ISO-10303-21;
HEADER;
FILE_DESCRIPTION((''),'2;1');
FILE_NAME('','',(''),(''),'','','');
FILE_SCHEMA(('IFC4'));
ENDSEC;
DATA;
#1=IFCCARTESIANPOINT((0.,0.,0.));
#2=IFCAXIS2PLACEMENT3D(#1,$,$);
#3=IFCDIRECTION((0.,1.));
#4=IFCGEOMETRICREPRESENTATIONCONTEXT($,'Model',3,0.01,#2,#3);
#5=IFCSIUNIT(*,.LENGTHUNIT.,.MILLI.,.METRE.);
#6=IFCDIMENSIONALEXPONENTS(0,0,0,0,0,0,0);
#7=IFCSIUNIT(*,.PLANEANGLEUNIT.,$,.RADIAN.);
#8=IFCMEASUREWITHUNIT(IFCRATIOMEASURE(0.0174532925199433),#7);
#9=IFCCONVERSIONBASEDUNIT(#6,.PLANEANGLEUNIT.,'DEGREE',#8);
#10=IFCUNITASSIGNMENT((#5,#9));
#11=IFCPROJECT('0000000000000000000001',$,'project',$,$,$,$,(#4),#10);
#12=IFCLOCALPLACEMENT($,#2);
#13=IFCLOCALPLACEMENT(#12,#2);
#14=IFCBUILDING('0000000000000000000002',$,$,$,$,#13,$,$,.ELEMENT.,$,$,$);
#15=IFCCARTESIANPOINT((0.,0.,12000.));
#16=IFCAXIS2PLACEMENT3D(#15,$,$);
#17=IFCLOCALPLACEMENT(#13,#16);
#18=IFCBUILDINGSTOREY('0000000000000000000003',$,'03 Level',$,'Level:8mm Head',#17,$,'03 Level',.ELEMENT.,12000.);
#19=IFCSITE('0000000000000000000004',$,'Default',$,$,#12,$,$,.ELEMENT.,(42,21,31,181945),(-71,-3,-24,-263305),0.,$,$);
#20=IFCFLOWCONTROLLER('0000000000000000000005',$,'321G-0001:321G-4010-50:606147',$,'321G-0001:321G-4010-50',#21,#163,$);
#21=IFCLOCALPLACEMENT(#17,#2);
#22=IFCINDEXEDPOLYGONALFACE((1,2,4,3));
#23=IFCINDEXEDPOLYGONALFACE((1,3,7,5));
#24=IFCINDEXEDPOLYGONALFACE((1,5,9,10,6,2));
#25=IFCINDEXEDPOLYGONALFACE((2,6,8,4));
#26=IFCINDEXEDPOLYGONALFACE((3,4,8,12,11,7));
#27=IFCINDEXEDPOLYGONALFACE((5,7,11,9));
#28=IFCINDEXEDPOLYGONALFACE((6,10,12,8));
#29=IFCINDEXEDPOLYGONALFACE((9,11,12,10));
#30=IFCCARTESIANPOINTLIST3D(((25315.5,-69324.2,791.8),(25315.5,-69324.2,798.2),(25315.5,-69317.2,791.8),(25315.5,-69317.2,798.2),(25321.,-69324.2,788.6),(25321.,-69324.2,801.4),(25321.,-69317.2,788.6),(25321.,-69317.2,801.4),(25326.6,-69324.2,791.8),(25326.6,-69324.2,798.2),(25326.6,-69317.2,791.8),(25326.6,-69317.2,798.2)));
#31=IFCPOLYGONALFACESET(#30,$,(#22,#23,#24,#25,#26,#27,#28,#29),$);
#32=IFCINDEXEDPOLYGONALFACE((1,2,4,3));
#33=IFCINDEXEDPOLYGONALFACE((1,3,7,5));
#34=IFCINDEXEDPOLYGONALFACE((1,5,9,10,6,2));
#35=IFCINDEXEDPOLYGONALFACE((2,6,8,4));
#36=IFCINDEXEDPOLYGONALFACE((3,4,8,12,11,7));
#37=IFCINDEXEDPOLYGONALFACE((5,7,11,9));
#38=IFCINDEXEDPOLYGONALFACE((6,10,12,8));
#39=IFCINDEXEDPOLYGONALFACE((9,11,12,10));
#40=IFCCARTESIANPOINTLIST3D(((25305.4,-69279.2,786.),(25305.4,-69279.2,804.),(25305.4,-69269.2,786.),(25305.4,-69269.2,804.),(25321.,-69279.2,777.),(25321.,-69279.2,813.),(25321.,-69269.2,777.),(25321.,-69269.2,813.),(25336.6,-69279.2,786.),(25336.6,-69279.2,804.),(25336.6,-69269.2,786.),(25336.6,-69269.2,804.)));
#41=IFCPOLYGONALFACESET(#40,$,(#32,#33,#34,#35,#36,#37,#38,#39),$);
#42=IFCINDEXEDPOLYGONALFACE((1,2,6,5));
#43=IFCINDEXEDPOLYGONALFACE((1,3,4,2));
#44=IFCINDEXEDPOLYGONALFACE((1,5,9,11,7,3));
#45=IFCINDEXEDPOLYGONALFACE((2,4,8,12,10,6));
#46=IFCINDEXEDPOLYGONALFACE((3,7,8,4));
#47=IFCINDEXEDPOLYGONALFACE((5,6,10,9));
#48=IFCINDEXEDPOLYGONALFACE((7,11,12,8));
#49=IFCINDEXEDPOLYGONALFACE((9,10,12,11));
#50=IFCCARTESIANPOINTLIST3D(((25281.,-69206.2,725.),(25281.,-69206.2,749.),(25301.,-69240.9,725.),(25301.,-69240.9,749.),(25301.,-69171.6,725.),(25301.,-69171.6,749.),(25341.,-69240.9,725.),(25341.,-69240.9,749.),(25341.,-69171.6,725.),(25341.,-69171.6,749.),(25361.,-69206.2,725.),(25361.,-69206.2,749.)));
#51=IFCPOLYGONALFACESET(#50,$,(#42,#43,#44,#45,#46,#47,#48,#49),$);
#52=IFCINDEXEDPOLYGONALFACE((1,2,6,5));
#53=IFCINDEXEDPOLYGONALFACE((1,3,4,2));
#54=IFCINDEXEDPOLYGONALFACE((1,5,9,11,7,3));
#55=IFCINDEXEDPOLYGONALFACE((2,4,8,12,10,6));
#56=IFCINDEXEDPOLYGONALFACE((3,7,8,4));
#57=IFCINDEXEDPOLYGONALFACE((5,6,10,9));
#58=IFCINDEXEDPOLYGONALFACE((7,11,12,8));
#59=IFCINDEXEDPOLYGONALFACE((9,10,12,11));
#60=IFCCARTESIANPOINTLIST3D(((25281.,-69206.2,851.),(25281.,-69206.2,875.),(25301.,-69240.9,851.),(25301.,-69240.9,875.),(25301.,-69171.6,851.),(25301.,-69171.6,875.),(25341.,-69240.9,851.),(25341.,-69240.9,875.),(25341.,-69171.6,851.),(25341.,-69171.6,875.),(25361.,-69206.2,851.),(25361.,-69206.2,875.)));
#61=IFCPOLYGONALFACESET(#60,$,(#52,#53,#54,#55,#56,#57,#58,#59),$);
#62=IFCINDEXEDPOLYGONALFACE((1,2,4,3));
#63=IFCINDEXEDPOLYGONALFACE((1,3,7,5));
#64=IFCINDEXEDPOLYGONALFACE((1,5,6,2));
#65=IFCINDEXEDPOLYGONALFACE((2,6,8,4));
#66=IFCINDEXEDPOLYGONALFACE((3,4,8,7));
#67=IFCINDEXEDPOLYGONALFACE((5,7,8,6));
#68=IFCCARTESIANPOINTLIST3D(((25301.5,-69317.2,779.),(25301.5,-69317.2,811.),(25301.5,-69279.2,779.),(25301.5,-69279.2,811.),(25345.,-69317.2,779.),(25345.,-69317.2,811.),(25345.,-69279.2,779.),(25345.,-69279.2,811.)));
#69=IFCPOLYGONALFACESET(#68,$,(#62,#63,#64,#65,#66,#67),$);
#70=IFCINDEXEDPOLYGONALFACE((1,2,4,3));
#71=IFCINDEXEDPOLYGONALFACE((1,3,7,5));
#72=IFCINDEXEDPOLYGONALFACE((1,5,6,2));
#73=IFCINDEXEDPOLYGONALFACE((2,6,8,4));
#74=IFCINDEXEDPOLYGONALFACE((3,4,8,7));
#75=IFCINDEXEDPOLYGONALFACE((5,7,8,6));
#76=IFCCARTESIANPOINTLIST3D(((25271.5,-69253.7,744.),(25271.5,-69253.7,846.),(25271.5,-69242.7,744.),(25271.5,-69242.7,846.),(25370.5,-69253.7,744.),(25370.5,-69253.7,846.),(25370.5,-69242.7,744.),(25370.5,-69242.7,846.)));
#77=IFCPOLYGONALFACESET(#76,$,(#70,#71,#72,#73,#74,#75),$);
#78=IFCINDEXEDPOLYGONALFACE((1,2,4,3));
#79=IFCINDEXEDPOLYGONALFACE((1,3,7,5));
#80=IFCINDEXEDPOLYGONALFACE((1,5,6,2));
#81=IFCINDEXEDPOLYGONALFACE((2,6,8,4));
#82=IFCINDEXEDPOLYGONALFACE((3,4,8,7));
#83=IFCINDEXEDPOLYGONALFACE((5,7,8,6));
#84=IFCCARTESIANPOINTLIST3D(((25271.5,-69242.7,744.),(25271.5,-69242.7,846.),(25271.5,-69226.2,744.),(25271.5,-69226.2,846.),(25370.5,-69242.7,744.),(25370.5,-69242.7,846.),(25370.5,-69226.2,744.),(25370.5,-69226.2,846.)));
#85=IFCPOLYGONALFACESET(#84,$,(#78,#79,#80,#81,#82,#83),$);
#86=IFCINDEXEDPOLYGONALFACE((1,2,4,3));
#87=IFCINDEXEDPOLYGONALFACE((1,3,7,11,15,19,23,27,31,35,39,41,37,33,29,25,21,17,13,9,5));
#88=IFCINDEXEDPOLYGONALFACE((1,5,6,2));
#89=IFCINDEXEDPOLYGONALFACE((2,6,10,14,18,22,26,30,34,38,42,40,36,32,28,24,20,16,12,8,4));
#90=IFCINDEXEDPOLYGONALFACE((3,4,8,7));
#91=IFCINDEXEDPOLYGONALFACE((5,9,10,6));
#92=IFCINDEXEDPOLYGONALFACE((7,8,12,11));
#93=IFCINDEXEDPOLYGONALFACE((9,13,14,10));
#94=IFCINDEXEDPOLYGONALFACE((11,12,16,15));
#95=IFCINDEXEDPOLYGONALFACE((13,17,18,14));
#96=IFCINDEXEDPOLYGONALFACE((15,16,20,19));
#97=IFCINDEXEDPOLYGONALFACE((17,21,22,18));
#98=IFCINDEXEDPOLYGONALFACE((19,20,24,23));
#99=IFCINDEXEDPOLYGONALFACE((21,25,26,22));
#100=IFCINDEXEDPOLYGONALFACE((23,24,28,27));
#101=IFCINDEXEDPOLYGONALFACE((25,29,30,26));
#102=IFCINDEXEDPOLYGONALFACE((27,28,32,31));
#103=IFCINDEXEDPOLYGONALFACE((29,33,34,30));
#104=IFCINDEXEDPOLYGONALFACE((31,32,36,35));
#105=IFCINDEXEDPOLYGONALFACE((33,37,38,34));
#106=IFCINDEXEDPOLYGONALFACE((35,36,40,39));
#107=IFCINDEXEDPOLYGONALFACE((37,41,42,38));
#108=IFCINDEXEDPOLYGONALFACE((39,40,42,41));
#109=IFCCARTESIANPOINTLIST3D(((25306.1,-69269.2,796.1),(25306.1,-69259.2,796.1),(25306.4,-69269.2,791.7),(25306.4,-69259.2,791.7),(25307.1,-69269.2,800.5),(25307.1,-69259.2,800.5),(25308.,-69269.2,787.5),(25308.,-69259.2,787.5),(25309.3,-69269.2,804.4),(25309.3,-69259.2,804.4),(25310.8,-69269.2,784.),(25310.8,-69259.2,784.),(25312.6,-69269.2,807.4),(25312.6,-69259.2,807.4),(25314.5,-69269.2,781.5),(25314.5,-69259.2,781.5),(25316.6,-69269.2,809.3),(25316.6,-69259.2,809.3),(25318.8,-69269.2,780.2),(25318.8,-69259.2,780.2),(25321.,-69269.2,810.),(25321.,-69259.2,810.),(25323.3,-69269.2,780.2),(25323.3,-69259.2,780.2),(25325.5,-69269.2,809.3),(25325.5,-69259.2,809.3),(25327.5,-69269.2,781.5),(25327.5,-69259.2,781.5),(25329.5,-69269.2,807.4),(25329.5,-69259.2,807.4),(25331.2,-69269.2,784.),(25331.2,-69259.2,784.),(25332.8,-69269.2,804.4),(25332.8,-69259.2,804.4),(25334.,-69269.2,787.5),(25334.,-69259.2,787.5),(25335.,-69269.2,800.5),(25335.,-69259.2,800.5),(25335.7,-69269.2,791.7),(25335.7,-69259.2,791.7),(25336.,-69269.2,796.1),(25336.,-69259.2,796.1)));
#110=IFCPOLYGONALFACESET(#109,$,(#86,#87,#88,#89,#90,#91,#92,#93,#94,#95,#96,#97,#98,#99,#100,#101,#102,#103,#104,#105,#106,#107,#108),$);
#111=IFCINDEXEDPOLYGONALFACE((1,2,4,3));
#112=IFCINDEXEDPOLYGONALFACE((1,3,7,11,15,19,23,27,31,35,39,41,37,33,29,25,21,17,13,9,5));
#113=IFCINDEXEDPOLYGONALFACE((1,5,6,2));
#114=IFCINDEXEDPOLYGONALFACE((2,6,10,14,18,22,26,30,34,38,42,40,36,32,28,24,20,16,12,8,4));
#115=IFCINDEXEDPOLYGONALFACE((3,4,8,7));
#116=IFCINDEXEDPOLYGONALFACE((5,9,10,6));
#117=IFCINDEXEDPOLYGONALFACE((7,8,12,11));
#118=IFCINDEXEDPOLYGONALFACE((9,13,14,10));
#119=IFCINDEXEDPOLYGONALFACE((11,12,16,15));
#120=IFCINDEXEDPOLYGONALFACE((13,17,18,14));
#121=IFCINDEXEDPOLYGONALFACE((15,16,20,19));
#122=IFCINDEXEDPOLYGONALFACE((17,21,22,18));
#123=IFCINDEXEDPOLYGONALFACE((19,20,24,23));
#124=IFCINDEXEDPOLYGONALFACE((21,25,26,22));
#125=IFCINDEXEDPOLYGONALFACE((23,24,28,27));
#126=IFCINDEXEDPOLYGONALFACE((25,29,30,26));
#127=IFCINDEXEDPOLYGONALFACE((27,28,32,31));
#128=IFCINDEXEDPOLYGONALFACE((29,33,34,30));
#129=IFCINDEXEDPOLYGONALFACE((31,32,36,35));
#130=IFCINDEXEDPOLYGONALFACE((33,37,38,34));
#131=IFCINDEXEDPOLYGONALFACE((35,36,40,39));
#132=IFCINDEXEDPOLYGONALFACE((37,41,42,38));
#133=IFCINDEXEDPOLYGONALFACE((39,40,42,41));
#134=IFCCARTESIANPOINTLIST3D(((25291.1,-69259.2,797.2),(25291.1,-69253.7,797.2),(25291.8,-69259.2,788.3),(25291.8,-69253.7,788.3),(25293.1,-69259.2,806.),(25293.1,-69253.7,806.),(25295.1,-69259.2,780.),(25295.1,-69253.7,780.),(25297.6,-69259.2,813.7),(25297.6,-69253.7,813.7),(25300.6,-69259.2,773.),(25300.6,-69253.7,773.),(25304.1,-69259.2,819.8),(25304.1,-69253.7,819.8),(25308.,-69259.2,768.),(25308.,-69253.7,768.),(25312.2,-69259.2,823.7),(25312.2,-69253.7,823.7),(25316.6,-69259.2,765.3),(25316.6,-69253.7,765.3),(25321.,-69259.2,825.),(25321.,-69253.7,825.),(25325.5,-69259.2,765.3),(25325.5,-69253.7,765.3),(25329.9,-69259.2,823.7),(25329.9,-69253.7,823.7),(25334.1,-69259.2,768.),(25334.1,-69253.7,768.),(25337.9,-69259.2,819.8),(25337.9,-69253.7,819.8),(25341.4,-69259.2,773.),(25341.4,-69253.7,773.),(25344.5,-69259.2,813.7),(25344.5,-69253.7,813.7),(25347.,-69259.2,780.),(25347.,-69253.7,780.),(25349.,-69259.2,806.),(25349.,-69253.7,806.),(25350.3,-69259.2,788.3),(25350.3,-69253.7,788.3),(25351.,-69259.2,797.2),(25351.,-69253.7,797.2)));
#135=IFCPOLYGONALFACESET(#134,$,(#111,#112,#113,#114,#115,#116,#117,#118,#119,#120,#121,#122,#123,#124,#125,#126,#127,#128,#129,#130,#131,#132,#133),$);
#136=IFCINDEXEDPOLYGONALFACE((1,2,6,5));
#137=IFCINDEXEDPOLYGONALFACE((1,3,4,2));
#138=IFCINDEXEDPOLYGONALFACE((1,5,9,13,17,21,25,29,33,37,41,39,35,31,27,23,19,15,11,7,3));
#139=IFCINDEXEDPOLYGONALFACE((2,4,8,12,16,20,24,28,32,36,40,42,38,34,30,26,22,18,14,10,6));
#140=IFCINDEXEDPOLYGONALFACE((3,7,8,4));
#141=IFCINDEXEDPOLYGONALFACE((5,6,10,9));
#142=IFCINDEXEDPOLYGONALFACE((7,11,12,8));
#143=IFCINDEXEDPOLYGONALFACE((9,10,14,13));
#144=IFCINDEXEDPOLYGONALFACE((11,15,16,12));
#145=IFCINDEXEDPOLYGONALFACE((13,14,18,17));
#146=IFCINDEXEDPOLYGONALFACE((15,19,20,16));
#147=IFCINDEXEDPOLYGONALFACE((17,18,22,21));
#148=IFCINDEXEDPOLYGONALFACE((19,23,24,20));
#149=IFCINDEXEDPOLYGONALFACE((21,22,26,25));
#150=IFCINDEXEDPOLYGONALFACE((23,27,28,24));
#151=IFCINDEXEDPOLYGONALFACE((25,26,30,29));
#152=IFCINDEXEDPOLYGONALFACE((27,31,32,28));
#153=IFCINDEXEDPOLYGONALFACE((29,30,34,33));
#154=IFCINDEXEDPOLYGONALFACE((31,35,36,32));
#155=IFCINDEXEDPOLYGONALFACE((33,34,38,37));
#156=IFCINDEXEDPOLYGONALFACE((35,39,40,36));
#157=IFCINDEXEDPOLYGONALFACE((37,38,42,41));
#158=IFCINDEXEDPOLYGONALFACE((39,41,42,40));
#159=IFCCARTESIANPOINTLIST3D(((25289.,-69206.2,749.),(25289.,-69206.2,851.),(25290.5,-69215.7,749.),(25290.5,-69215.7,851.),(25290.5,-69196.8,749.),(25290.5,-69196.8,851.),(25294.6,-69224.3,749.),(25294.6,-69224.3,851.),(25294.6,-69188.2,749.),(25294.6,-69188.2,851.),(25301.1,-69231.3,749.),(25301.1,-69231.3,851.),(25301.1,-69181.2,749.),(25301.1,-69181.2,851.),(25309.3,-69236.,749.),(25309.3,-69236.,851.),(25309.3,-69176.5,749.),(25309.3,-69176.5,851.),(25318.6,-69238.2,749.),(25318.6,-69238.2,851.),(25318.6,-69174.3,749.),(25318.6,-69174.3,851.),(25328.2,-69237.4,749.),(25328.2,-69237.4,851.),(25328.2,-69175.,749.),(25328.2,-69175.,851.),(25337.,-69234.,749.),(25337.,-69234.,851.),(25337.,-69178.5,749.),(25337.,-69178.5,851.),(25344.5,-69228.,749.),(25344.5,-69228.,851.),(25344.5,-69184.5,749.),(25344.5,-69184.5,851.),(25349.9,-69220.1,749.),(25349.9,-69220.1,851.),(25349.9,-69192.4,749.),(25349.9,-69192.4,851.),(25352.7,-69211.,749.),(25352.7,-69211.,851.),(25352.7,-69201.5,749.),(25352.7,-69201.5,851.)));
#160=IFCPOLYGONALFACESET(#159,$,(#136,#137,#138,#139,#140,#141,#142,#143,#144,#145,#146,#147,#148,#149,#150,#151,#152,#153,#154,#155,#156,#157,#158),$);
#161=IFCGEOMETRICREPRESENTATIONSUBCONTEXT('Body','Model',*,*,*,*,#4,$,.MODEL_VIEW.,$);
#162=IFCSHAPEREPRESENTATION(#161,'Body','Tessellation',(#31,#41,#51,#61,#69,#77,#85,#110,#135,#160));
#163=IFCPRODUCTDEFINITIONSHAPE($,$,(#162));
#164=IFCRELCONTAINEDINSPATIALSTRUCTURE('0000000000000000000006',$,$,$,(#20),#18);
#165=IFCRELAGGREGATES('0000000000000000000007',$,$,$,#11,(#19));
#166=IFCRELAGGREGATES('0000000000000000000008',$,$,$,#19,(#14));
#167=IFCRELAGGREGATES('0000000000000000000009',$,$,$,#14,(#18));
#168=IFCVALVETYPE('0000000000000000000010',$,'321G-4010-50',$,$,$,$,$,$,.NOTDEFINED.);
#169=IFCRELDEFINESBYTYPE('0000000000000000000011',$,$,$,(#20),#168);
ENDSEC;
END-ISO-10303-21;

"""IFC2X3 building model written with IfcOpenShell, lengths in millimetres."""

from ifc_helpers import new_model, entity, si_unit, converted_unit, direction, frame, frame_2d, origin, origin_2d_with_axis, place, context, subcontext, project, spatial, polyline, rectangle, circle, outline, extrude, source, transform, mapped, type_object, type_shapes, element, save


model = new_model("IFC2X3")

# Units and contexts
model_context = context("Model", 3, precision=0.01, world=origin(), true_north=direction((0.0, 1.0)))
body_context = subcontext(model_context, "Body", "Model", "MODEL_VIEW")
ifc_project = project(units=[si_unit("LENGTHUNIT", "METRE", prefix="MILLI"), converted_unit("PLANEANGLEUNIT", "DEGREE", entity("IfcRatioMeasure", 0.0174532925199433), si_unit("PLANEANGLEUNIT", "RADIAN"), dimensions=[0, 0, 0, 0, 0, 0, 0])], contexts=[model_context])

# Site, building, storey
site_placement = place(None, origin())
site = spatial("IfcSite", under=ifc_project, at=site_placement, Name="Default", CompositionType="ELEMENT", RefLatitude=(42, 21, 31, 181945), RefLongitude=(-71, -3, -24, -263305), RefElevation=0.0)
building_placement = place(site_placement, origin())
building = spatial("IfcBuilding", under=site, at=building_placement, CompositionType="ELEMENT")
storey_placement = place(building_placement, frame((0.0, 0.0, 12000.0)))
storey = spatial("IfcBuildingStorey", under=building, at=storey_placement, Name="03 Level", ObjectType="Level:8mm Head", LongName="03 Level", CompositionType="ELEMENT", Elevation=12000.0)

# Flow controller
valve_type_1 = type_object("IfcValveType", Name="321G-4010-50", PredefinedType="NOTDEFINED")
shared_shape_1 = source(origin(), body_context, "Body", "SweptSolid", [
    extrude(outline(polyline([(-3.2, -5.5), (3.2, -5.5), (6.4, 0.0), (3.2, 5.5), (-3.2, 5.5), (-6.4, 0.0), (-3.2, -5.5)])), frame((-5.0, 0.0, 111.0), z_axis=(0.0, 0.0, 1.0), x_axis=(-1.0, 0.0, 0.0)), (0.0, 0.0, 1.0), 7.0),
    extrude(outline(polyline([(-9.0, -15.6), (9.0, -15.6), (18.0, 0.0), (9.0, 15.6), (-9.0, 15.6), (-18.0, 0.0), (-9.0, -15.6)])), frame((-5.0, 0.0, 63.0), z_axis=(0.0, 0.0, 1.0), x_axis=(-1.0, 0.0, 0.0)), (0.0, 0.0, 1.0), 10.0),
    extrude(outline(polyline([(-20.0, -34.6), (20.0, -34.6), (40.0, 0.0), (20.0, 34.6), (-20.0, 34.6), (-40.0, 0.0), (-20.0, -34.6)])), frame((-75.0, 0.0, 0.0), z_axis=(1.0, 0.0, 0.0), x_axis=(0.0, -1.0, 0.0)), (0.0, 0.0, 1.0), 24.0),
    extrude(outline(polyline([(-20.0, -34.6), (20.0, -34.6), (40.0, 0.0), (20.0, 34.6), (-20.0, 34.6), (-40.0, 0.0), (-20.0, -34.6)])), frame((51.0, 0.0, 0.0), z_axis=(1.0, 0.0, 0.0), x_axis=(0.0, -1.0, 0.0)), (0.0, 0.0, 1.0), 24.0),
    extrude(rectangle(XDim=32.0, YDim=43.5, at=origin_2d_with_axis()), frame((-5.0, -2.2, 73.0)), (0.0, 0.0, 1.0), 38.0),
    extrude(rectangle(XDim=102.0, YDim=99.0, at=origin_2d_with_axis()), frame((-5.0, 0.0, 36.5)), (0.0, 0.0, 1.0), 11.0),
    extrude(rectangle(XDim=102.0, YDim=99.0, at=origin_2d_with_axis()), frame((-5.0, 0.0, 20.0)), (0.0, 0.0, 1.0), 16.5),
    extrude(circle(Radius=15.0, at=frame_2d((0.0, 0.0), x_axis=(1.0, 0.0))), frame((-5.0, 0.0, 53.0)), (0.0, 0.0, 1.0), 10.0),
    extrude(circle(Radius=30.0, at=frame_2d((0.0, 0.0), x_axis=(1.0, 0.0))), frame((-5.0, 0.0, 47.5)), (0.0, 0.0, 1.0), 5.5),
    extrude(circle(Radius=32.0, at=frame_2d((0.0, 0.0), x_axis=(1.0, 0.0))), frame((-51.0, 0.0, 0.0), z_axis=(1.0, 0.0, 0.0), x_axis=(0.0, 1.0, 0.0)), (0.0, 0.0, 1.0), 102.0),
])
type_shapes(valve_type_1, [shared_shape_1])
flow_controller_1_placement = place(storey_placement, frame((25321.0, -69206.2, 800.0), z_axis=(0.0, -1.0, 0.0), x_axis=(0.0, 0.0, 1.0)))
element("IfcFlowController", 1, at=flow_controller_1_placement, inside=storey, type_object=valve_type_1, Name="321G-0001:321G-4010-50:606147", ObjectType="321G-0001:321G-4010-50", context=body_context, shape_type="MappedRepresentation", body=[
    mapped(shared_shape_1, transform((0.0, 0.0, 0.0), scale=1.0)),
])

save(model, "model.ifc")
